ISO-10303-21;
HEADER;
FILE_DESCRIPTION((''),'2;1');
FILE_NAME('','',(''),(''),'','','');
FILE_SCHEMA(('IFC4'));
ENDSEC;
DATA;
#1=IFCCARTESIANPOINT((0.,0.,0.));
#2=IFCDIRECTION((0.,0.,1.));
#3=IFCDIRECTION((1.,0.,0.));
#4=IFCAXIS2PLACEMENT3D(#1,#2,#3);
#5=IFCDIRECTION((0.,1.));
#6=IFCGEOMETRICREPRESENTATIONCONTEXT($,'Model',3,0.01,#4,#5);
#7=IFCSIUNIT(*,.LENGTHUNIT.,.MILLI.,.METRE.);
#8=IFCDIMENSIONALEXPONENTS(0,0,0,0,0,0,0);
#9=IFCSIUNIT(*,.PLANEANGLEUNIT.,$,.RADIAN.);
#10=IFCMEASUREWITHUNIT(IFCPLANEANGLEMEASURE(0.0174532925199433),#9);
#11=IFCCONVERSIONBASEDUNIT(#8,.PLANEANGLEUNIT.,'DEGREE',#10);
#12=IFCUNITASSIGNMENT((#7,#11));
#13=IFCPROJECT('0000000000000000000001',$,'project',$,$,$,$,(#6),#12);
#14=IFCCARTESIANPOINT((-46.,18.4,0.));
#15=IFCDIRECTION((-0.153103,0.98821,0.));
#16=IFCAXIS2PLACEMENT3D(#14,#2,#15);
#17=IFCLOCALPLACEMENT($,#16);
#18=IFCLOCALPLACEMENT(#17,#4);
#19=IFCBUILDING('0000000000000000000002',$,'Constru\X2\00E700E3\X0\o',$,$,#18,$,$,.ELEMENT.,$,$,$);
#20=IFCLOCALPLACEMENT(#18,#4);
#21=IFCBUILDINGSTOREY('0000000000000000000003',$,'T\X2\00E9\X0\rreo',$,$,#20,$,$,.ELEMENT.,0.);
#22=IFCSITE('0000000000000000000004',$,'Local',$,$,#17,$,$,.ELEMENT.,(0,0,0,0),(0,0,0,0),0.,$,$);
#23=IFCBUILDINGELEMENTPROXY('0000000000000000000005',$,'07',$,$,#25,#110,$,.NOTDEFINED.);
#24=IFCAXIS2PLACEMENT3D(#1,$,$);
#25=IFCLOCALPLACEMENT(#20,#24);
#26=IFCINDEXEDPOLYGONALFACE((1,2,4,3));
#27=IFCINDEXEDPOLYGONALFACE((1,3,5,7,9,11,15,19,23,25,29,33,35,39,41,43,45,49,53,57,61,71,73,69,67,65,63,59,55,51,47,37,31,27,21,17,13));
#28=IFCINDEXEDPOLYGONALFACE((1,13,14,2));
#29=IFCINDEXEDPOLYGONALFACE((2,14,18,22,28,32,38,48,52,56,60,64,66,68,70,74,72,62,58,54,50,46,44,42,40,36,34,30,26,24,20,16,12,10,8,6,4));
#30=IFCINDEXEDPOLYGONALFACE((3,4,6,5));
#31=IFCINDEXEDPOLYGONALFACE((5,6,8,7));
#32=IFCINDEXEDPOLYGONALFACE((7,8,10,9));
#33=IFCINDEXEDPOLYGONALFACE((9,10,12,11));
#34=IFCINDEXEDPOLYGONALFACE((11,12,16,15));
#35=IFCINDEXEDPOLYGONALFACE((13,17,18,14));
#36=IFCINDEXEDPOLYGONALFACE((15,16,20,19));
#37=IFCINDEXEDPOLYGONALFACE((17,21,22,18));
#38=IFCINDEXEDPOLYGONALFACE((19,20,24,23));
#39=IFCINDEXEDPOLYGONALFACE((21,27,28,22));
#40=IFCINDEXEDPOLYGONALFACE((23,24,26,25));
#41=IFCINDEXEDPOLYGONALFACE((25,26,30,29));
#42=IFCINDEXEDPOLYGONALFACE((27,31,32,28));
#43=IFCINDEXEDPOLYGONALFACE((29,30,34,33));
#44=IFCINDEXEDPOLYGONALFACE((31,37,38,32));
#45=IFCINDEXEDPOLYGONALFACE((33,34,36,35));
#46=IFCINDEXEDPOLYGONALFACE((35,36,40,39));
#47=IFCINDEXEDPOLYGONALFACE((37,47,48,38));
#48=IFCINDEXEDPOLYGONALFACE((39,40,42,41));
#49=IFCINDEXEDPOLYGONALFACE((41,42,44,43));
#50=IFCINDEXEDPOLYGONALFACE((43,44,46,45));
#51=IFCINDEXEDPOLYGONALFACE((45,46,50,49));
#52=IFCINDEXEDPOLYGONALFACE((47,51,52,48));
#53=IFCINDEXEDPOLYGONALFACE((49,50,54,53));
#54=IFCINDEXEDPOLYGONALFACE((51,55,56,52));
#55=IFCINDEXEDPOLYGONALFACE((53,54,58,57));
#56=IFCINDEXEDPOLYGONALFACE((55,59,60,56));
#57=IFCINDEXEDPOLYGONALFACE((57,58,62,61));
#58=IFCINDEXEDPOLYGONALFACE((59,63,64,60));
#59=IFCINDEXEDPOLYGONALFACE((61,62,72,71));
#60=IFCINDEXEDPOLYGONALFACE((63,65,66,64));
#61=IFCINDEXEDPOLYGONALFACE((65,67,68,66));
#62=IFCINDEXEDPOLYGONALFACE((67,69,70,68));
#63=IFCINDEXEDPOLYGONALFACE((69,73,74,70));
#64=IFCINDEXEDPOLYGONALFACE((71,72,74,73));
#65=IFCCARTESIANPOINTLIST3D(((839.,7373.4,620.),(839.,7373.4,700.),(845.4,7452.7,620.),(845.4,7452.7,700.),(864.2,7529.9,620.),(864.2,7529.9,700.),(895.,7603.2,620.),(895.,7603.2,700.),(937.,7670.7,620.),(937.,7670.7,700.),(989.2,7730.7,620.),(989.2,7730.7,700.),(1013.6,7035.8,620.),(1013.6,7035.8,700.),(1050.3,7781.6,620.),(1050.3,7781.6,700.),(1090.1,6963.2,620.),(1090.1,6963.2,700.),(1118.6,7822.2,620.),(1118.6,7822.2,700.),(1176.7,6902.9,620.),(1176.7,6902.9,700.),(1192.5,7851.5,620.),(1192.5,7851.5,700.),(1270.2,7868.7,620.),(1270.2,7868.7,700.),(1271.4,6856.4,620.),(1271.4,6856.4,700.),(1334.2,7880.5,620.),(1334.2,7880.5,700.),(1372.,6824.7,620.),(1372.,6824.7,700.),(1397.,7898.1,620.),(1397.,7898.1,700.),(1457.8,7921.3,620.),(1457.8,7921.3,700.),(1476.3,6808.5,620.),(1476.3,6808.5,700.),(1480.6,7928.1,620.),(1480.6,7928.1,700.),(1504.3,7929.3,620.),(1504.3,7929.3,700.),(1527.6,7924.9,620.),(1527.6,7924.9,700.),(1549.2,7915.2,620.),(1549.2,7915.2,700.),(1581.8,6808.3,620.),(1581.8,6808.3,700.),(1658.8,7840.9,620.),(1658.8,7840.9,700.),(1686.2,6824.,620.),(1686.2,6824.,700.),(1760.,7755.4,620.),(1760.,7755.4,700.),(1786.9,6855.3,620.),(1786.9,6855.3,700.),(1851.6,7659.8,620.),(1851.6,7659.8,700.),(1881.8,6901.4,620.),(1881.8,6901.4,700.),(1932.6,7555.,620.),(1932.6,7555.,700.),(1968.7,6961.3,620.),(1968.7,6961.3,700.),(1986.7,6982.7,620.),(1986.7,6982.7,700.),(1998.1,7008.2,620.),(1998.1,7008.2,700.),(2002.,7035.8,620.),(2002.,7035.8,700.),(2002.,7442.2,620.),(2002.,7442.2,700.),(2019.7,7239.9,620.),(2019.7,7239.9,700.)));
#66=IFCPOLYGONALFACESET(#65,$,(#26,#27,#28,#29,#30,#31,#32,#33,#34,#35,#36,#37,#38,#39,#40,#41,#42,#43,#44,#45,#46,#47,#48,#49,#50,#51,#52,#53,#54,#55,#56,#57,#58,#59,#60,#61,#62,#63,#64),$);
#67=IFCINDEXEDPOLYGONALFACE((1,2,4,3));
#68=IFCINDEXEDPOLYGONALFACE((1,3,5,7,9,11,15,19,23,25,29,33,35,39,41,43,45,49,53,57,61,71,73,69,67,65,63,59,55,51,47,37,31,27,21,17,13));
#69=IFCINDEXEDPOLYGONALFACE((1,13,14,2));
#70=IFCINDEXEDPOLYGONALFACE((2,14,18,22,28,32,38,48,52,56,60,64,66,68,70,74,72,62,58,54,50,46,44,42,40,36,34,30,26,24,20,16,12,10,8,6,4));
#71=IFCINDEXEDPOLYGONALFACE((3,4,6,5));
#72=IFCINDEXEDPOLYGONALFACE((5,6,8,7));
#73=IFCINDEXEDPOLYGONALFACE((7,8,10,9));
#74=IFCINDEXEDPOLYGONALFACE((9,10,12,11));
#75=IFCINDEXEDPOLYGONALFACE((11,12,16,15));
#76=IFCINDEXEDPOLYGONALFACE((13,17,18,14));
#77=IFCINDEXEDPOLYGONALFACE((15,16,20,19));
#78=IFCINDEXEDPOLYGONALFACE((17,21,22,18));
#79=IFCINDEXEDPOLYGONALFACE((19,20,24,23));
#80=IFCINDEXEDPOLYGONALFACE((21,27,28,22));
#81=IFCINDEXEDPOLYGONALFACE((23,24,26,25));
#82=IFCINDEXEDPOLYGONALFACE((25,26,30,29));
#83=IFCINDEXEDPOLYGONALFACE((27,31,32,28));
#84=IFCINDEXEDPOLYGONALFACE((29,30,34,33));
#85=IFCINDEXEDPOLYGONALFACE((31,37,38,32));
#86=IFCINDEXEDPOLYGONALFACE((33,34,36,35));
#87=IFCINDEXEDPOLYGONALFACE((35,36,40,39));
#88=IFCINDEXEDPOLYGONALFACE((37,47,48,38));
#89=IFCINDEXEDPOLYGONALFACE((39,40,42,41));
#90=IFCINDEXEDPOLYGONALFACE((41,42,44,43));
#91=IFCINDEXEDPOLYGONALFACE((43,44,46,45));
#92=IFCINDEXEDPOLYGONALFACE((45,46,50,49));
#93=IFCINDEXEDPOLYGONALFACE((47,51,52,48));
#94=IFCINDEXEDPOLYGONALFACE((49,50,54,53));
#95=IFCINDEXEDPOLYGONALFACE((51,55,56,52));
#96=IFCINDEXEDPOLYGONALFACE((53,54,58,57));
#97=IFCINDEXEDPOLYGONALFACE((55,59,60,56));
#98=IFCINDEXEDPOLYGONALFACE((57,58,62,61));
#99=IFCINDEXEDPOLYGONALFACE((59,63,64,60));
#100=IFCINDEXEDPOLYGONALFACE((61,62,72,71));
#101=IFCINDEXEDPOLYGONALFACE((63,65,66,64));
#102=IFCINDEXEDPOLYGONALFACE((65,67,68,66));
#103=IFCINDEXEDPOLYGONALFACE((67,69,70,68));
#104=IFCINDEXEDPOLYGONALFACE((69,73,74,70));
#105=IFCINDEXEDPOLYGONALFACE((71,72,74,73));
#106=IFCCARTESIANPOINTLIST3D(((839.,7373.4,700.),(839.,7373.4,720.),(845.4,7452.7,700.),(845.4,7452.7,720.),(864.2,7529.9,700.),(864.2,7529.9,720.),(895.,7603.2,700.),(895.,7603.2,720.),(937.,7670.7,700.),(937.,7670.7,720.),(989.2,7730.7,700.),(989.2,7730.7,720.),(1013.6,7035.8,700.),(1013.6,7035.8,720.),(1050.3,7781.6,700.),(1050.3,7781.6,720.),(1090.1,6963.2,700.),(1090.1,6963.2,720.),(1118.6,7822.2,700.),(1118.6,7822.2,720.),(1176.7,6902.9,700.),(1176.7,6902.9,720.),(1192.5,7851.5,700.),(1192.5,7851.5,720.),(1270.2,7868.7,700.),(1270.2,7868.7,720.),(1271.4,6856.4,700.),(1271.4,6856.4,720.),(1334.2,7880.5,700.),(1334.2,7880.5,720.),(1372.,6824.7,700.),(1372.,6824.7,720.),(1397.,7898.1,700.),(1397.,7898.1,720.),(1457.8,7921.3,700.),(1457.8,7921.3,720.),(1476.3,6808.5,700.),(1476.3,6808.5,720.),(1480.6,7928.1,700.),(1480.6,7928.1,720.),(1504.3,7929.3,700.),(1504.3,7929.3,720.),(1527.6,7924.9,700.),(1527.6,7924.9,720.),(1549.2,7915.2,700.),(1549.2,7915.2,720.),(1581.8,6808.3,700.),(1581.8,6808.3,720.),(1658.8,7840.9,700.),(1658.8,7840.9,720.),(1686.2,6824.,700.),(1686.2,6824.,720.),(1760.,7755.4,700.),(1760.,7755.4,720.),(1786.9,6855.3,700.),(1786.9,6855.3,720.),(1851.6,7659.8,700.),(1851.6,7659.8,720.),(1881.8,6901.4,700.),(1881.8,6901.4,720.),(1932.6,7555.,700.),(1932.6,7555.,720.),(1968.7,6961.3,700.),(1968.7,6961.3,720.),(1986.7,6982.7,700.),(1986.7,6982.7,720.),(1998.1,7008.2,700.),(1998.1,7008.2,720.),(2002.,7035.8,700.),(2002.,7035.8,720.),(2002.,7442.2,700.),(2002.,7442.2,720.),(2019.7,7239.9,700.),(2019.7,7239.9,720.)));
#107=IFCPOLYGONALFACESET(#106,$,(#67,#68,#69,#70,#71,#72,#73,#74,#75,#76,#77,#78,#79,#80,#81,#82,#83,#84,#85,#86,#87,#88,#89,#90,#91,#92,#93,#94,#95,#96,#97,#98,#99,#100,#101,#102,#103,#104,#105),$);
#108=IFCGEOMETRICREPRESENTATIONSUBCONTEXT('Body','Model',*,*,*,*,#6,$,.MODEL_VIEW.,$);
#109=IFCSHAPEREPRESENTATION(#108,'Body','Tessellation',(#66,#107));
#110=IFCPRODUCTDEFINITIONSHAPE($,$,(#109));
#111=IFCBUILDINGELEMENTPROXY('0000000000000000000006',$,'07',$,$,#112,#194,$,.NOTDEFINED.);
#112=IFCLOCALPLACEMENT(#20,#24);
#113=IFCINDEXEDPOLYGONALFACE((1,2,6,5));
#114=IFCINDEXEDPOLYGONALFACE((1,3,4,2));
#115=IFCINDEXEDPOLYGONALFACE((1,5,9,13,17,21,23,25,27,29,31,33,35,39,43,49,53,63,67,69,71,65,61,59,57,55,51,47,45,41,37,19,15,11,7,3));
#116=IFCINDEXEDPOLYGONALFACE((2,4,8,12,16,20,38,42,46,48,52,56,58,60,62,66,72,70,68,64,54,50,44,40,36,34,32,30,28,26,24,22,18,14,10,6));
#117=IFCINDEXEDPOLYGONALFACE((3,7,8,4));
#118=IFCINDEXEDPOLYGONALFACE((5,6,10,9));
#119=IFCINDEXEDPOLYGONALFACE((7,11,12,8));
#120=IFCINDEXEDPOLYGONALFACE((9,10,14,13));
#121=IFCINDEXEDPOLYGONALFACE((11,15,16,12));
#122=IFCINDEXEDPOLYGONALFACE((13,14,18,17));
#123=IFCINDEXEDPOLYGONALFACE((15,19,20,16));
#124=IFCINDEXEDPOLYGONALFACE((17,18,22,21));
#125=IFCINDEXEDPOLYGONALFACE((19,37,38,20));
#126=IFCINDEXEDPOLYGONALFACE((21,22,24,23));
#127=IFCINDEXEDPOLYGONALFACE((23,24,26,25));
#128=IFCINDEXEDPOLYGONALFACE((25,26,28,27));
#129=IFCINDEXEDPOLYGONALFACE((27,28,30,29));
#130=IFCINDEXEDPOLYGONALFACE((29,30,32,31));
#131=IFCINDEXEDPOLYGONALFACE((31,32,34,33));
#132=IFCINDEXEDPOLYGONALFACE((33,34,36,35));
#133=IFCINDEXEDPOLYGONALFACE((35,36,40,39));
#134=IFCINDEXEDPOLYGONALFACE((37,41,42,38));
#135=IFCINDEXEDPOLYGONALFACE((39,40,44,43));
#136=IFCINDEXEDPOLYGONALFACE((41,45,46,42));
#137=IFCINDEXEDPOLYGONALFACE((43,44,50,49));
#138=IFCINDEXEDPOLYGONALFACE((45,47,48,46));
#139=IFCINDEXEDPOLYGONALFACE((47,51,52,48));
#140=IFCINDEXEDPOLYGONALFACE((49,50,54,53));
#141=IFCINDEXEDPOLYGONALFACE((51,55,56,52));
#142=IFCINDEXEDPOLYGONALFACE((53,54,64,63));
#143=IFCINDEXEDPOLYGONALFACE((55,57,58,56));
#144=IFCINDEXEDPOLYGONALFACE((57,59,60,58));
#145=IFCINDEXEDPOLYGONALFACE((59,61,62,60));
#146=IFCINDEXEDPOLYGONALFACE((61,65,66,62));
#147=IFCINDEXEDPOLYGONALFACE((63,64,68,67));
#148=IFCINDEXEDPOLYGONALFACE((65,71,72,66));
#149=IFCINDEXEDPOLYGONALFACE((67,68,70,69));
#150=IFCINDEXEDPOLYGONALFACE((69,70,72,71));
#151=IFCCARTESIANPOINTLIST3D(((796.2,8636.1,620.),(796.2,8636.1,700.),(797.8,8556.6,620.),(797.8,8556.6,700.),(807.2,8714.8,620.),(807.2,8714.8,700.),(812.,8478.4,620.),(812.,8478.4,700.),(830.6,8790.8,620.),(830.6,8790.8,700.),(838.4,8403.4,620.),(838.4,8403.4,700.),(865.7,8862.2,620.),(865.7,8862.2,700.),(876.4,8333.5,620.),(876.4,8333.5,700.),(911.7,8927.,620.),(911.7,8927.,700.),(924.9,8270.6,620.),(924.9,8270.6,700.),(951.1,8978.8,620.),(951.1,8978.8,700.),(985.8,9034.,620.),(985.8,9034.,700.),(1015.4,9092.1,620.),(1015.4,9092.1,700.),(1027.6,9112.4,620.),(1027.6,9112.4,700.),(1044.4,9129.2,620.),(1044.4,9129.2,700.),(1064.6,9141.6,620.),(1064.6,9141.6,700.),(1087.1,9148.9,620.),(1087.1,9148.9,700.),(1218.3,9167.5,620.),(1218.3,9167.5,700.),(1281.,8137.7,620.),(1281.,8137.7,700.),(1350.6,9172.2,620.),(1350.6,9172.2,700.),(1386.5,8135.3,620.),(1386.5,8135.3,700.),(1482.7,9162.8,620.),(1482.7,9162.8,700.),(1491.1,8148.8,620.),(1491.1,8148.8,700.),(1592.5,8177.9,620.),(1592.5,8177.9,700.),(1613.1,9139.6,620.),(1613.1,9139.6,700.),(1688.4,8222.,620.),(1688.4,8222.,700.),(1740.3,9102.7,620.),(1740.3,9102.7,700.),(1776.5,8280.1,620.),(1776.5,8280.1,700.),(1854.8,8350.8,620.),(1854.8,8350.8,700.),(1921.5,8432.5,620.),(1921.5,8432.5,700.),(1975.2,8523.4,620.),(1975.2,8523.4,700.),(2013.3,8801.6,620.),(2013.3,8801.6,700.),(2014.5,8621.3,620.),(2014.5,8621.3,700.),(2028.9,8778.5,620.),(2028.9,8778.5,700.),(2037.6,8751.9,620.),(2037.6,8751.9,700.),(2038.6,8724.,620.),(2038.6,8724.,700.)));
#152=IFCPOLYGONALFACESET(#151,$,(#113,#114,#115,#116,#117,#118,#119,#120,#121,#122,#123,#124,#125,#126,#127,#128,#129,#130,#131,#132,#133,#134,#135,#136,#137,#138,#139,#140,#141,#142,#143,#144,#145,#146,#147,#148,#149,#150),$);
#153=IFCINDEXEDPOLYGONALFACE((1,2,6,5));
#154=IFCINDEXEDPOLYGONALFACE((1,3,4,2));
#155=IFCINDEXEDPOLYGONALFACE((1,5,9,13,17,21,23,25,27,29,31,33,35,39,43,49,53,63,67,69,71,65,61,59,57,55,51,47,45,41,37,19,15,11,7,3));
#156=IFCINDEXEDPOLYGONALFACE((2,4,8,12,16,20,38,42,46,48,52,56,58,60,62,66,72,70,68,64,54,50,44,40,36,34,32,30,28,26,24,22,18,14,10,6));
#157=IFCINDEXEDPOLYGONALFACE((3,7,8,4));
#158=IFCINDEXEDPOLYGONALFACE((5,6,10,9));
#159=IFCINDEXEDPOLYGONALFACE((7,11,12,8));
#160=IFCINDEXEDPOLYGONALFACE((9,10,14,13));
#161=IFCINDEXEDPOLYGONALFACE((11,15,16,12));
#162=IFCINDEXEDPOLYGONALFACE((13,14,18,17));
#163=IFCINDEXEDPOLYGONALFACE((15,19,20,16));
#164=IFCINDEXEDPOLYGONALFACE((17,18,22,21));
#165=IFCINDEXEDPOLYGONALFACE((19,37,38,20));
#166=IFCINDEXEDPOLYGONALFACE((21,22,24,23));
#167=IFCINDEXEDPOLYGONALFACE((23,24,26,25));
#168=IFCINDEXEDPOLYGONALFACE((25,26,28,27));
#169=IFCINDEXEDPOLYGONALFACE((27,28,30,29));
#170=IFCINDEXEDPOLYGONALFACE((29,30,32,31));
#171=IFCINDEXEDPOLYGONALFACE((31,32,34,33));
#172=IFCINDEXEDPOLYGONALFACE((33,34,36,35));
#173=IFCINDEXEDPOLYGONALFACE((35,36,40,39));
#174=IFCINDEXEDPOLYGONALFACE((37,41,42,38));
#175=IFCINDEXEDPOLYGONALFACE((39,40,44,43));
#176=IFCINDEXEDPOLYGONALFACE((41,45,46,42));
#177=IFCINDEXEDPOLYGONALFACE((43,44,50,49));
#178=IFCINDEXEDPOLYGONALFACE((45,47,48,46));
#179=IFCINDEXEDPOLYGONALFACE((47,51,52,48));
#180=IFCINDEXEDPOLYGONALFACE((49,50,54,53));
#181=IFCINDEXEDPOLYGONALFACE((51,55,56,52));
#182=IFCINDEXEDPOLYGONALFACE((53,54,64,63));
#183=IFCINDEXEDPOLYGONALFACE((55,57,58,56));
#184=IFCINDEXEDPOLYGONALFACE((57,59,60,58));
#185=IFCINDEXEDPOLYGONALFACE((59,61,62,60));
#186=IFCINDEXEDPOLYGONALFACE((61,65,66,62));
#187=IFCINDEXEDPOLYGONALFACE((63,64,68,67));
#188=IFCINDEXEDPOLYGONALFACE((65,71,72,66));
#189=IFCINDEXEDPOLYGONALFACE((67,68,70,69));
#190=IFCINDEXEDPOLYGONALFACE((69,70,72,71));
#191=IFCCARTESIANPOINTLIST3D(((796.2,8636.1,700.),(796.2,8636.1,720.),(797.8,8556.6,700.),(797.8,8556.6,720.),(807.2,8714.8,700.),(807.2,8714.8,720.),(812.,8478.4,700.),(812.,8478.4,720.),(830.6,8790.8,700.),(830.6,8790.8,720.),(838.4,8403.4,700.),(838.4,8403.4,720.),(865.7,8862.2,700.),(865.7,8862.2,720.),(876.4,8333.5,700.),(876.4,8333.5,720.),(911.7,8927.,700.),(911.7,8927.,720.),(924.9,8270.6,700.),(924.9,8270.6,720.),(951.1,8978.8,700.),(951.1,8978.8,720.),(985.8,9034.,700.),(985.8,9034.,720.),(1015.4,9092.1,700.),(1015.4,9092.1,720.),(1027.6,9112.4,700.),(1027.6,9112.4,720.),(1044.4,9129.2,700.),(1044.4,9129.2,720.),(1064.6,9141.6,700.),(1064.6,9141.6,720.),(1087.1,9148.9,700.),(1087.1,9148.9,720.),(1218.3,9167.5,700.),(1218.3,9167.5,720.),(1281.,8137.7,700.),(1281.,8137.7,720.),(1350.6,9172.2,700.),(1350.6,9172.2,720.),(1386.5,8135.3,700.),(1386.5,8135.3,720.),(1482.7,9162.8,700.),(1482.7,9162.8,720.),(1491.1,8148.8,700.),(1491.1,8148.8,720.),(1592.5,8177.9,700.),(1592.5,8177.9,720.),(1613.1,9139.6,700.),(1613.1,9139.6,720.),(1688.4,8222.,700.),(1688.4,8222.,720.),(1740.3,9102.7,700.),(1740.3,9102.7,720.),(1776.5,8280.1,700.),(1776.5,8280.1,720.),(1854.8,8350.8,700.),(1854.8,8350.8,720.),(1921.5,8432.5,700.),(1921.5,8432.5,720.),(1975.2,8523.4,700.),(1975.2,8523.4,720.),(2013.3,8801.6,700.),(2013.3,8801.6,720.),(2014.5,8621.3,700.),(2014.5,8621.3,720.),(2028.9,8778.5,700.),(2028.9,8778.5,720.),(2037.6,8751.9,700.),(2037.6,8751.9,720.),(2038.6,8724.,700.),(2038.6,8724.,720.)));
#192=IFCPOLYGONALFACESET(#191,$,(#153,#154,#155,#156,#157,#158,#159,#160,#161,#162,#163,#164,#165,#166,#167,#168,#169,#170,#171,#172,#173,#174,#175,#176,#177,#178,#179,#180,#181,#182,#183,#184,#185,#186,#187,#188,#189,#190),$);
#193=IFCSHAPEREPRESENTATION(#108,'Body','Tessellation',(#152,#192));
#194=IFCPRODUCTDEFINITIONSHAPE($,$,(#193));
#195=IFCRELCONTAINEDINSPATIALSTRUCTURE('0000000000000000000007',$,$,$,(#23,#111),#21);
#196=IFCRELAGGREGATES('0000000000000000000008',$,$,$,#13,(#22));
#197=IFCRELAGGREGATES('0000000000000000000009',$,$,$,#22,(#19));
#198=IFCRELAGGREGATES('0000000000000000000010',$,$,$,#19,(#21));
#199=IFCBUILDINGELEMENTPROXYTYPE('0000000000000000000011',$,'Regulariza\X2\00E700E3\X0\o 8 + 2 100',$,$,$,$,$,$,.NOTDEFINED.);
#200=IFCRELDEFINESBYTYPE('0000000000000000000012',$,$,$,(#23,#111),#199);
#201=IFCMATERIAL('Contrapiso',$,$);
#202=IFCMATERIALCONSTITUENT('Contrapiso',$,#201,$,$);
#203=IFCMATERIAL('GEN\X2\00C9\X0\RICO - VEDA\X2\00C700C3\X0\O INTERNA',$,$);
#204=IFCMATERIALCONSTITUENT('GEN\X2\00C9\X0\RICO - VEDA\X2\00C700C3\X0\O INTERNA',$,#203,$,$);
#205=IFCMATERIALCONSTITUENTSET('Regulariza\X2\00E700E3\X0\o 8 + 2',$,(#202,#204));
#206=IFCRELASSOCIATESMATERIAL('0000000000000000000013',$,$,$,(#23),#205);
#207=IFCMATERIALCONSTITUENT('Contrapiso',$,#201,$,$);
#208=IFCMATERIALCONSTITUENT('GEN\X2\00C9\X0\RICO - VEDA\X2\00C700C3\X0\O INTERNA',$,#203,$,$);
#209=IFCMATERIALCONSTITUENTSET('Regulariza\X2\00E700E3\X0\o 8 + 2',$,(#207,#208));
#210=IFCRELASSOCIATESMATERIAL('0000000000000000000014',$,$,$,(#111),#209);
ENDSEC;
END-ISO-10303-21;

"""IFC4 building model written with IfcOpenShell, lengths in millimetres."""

from ifc_helpers import new_model, entity, si_unit, converted_unit, direction, frame, origin_with_axes, place, context, subcontext, project, spatial, line, arc, indexed_curve, outline, extrude, material, constituent, constituent_set, type_object, element, save


model = new_model("IFC4")

# Units and contexts
model_context = context("Model", 3, precision=0.01, world=origin_with_axes(), true_north=direction((0.0, 1.0)))
body_context = subcontext(model_context, "Body", "Model", "MODEL_VIEW")
ifc_project = project(units=[si_unit("LENGTHUNIT", "METRE", prefix="MILLI"), converted_unit("PLANEANGLEUNIT", "DEGREE", entity("IfcPlaneAngleMeasure", 0.0174532925199433), si_unit("PLANEANGLEUNIT", "RADIAN"), dimensions=[0, 0, 0, 0, 0, 0, 0])], contexts=[model_context])

# Site, building, storey
site_placement = place(None, frame((-46.0, 18.4, 0.0), z_axis=(0.0, 0.0, 1.0), x_axis=(-0.153103, 0.98821, 0.0)))
site = spatial("IfcSite", under=ifc_project, at=site_placement, Name="Local", CompositionType="ELEMENT", RefLatitude=(0, 0, 0, 0), RefLongitude=(0, 0, 0, 0), RefElevation=0.0)
building_placement = place(site_placement, origin_with_axes())
building = spatial("IfcBuilding", under=site, at=building_placement, Name="Construção", CompositionType="ELEMENT")
storey_placement = place(building_placement, origin_with_axes())
storey = spatial("IfcBuildingStorey", under=building, at=storey_placement, Name="Térreo", CompositionType="ELEMENT", Elevation=0.0)

# Shared definitions
ifc_material_1 = material(Name="GENÉRICO - VEDAÇÃO INTERNA")

# Building element proxies
ifc_material_2 = material(Name="Contrapiso")
ifc_constituent_1 = constituent(ifc_material_2, Name="Contrapiso")
ifc_constituent_2 = constituent(ifc_material_1, Name="GENÉRICO - VEDAÇÃO INTERNA")
ifc_constituent_set_1 = constituent_set(constituents=[ifc_constituent_1, ifc_constituent_2], Name="Regularização 8 + 2")
building_element_proxy_type_1 = type_object("IfcBuildingElementProxyType", Name="Regularização 8 + 2 100", PredefinedType="NOTDEFINED")
proxy_1_placement = place(storey_placement, frame((1013.6, 7035.8, 720.0), z_axis=(0.0, 0.0, 1.0), x_axis=(1.0, 0.0, 0.0)))
element("IfcBuildingElementProxy", 1, at=proxy_1_placement, inside=storey, type_object=building_element_proxy_type_1, material=ifc_constituent_set_1, Name="07", PredefinedType="NOTDEFINED", context=body_context, shape_type="SweptSolid", body=[
    extrude(outline(indexed_curve([(0.0, 0.0), (462.7, -227.3), (955.1, -74.5), (979.7, -40.8), (988.4, 0.0), (1006.1, 204.1), (988.4, 406.4), (793.5, 673.0), (535.6, 879.3), (490.7, 893.4), (444.3, 885.4), (352.2, 852.8), (256.6, 832.8), (-51.7, 665.9), (-174.6, 337.6)], segments=[arc(1, 2, 3), arc(3, 4, 5), line(5, 6, 7), arc(7, 8, 9), arc(9, 10, 11), arc(11, 12, 13), arc(13, 14, 15), line(15, 1)])), frame((0.0, 0.0, -100.0), z_axis=(0.0, 0.0, 1.0), x_axis=(1.0, 0.0, 0.0)), (0.0, 0.0, 1.0), 80.0),
    extrude(outline(indexed_curve([(0.0, 0.0), (462.7, -227.3), (955.1, -74.5), (979.7, -40.8), (988.4, 0.0), (1006.1, 204.1), (988.4, 406.4), (793.5, 673.0), (535.6, 879.3), (490.7, 893.4), (444.3, 885.4), (352.2, 852.8), (256.6, 832.8), (-51.7, 665.9), (-174.6, 337.6)], segments=[arc(1, 2, 3), arc(3, 4, 5), line(5, 6, 7), arc(7, 8, 9), arc(9, 10, 11), arc(11, 12, 13), arc(13, 14, 15), line(15, 1)])), frame((0.0, 0.0, -20.0), z_axis=(0.0, 0.0, 1.0), x_axis=(1.0, 0.0, 0.0)), (0.0, 0.0, 1.0), 20.0),
])
ifc_constituent_3 = constituent(ifc_material_2, Name="Contrapiso")
ifc_constituent_4 = constituent(ifc_material_1, Name="GENÉRICO - VEDAÇÃO INTERNA")
ifc_constituent_set_2 = constituent_set(constituents=[ifc_constituent_3, ifc_constituent_4], Name="Regularização 8 + 2")
proxy_2_placement = place(storey_placement, frame((1281.0, 8137.7, 720.0), z_axis=(0.0, 0.0, 1.0), x_axis=(1.0, 0.0, 0.0)))
element("IfcBuildingElementProxy", 2, at=proxy_2_placement, inside=storey, type_object=building_element_proxy_type_1, material=ifc_constituent_set_2, Name="07", PredefinedType="NOTDEFINED", context=body_context, shape_type="SweptSolid", body=[
    extrude(outline(indexed_curve([(0.0, 0.0), (495.5, 142.4), (757.6, 586.3), (753.2, 627.8), (732.3, 663.9), (459.3, 965.0), (135.8, 1031.5), (-193.8, 1011.2), (-236.6, 991.5), (-265.6, 954.4), (-311.9, 868.3), (-369.3, 789.3), (-485.6, 458.6), (-356.1, 132.9)], segments=[arc(1, 2, 3), arc(3, 4, 5), line(5, 6), arc(6, 7, 8), arc(8, 9, 10), arc(10, 11, 12), arc(12, 13, 14), line(14, 1)])), frame((0.0, 0.0, -100.0), z_axis=(0.0, 0.0, 1.0), x_axis=(1.0, 0.0, 0.0)), (0.0, 0.0, 1.0), 80.0),
    extrude(outline(indexed_curve([(0.0, 0.0), (495.5, 142.4), (757.6, 586.3), (753.2, 627.8), (732.3, 663.9), (459.3, 965.0), (135.8, 1031.5), (-193.8, 1011.2), (-236.6, 991.5), (-265.6, 954.4), (-311.9, 868.3), (-369.3, 789.3), (-485.6, 458.6), (-356.1, 132.9)], segments=[arc(1, 2, 3), arc(3, 4, 5), line(5, 6), arc(6, 7, 8), arc(8, 9, 10), arc(10, 11, 12), arc(12, 13, 14), line(14, 1)])), frame((0.0, 0.0, -20.0), z_axis=(0.0, 0.0, 1.0), x_axis=(1.0, 0.0, 0.0)), (0.0, 0.0, 1.0), 20.0),
])

save(model, "model.ifc")
